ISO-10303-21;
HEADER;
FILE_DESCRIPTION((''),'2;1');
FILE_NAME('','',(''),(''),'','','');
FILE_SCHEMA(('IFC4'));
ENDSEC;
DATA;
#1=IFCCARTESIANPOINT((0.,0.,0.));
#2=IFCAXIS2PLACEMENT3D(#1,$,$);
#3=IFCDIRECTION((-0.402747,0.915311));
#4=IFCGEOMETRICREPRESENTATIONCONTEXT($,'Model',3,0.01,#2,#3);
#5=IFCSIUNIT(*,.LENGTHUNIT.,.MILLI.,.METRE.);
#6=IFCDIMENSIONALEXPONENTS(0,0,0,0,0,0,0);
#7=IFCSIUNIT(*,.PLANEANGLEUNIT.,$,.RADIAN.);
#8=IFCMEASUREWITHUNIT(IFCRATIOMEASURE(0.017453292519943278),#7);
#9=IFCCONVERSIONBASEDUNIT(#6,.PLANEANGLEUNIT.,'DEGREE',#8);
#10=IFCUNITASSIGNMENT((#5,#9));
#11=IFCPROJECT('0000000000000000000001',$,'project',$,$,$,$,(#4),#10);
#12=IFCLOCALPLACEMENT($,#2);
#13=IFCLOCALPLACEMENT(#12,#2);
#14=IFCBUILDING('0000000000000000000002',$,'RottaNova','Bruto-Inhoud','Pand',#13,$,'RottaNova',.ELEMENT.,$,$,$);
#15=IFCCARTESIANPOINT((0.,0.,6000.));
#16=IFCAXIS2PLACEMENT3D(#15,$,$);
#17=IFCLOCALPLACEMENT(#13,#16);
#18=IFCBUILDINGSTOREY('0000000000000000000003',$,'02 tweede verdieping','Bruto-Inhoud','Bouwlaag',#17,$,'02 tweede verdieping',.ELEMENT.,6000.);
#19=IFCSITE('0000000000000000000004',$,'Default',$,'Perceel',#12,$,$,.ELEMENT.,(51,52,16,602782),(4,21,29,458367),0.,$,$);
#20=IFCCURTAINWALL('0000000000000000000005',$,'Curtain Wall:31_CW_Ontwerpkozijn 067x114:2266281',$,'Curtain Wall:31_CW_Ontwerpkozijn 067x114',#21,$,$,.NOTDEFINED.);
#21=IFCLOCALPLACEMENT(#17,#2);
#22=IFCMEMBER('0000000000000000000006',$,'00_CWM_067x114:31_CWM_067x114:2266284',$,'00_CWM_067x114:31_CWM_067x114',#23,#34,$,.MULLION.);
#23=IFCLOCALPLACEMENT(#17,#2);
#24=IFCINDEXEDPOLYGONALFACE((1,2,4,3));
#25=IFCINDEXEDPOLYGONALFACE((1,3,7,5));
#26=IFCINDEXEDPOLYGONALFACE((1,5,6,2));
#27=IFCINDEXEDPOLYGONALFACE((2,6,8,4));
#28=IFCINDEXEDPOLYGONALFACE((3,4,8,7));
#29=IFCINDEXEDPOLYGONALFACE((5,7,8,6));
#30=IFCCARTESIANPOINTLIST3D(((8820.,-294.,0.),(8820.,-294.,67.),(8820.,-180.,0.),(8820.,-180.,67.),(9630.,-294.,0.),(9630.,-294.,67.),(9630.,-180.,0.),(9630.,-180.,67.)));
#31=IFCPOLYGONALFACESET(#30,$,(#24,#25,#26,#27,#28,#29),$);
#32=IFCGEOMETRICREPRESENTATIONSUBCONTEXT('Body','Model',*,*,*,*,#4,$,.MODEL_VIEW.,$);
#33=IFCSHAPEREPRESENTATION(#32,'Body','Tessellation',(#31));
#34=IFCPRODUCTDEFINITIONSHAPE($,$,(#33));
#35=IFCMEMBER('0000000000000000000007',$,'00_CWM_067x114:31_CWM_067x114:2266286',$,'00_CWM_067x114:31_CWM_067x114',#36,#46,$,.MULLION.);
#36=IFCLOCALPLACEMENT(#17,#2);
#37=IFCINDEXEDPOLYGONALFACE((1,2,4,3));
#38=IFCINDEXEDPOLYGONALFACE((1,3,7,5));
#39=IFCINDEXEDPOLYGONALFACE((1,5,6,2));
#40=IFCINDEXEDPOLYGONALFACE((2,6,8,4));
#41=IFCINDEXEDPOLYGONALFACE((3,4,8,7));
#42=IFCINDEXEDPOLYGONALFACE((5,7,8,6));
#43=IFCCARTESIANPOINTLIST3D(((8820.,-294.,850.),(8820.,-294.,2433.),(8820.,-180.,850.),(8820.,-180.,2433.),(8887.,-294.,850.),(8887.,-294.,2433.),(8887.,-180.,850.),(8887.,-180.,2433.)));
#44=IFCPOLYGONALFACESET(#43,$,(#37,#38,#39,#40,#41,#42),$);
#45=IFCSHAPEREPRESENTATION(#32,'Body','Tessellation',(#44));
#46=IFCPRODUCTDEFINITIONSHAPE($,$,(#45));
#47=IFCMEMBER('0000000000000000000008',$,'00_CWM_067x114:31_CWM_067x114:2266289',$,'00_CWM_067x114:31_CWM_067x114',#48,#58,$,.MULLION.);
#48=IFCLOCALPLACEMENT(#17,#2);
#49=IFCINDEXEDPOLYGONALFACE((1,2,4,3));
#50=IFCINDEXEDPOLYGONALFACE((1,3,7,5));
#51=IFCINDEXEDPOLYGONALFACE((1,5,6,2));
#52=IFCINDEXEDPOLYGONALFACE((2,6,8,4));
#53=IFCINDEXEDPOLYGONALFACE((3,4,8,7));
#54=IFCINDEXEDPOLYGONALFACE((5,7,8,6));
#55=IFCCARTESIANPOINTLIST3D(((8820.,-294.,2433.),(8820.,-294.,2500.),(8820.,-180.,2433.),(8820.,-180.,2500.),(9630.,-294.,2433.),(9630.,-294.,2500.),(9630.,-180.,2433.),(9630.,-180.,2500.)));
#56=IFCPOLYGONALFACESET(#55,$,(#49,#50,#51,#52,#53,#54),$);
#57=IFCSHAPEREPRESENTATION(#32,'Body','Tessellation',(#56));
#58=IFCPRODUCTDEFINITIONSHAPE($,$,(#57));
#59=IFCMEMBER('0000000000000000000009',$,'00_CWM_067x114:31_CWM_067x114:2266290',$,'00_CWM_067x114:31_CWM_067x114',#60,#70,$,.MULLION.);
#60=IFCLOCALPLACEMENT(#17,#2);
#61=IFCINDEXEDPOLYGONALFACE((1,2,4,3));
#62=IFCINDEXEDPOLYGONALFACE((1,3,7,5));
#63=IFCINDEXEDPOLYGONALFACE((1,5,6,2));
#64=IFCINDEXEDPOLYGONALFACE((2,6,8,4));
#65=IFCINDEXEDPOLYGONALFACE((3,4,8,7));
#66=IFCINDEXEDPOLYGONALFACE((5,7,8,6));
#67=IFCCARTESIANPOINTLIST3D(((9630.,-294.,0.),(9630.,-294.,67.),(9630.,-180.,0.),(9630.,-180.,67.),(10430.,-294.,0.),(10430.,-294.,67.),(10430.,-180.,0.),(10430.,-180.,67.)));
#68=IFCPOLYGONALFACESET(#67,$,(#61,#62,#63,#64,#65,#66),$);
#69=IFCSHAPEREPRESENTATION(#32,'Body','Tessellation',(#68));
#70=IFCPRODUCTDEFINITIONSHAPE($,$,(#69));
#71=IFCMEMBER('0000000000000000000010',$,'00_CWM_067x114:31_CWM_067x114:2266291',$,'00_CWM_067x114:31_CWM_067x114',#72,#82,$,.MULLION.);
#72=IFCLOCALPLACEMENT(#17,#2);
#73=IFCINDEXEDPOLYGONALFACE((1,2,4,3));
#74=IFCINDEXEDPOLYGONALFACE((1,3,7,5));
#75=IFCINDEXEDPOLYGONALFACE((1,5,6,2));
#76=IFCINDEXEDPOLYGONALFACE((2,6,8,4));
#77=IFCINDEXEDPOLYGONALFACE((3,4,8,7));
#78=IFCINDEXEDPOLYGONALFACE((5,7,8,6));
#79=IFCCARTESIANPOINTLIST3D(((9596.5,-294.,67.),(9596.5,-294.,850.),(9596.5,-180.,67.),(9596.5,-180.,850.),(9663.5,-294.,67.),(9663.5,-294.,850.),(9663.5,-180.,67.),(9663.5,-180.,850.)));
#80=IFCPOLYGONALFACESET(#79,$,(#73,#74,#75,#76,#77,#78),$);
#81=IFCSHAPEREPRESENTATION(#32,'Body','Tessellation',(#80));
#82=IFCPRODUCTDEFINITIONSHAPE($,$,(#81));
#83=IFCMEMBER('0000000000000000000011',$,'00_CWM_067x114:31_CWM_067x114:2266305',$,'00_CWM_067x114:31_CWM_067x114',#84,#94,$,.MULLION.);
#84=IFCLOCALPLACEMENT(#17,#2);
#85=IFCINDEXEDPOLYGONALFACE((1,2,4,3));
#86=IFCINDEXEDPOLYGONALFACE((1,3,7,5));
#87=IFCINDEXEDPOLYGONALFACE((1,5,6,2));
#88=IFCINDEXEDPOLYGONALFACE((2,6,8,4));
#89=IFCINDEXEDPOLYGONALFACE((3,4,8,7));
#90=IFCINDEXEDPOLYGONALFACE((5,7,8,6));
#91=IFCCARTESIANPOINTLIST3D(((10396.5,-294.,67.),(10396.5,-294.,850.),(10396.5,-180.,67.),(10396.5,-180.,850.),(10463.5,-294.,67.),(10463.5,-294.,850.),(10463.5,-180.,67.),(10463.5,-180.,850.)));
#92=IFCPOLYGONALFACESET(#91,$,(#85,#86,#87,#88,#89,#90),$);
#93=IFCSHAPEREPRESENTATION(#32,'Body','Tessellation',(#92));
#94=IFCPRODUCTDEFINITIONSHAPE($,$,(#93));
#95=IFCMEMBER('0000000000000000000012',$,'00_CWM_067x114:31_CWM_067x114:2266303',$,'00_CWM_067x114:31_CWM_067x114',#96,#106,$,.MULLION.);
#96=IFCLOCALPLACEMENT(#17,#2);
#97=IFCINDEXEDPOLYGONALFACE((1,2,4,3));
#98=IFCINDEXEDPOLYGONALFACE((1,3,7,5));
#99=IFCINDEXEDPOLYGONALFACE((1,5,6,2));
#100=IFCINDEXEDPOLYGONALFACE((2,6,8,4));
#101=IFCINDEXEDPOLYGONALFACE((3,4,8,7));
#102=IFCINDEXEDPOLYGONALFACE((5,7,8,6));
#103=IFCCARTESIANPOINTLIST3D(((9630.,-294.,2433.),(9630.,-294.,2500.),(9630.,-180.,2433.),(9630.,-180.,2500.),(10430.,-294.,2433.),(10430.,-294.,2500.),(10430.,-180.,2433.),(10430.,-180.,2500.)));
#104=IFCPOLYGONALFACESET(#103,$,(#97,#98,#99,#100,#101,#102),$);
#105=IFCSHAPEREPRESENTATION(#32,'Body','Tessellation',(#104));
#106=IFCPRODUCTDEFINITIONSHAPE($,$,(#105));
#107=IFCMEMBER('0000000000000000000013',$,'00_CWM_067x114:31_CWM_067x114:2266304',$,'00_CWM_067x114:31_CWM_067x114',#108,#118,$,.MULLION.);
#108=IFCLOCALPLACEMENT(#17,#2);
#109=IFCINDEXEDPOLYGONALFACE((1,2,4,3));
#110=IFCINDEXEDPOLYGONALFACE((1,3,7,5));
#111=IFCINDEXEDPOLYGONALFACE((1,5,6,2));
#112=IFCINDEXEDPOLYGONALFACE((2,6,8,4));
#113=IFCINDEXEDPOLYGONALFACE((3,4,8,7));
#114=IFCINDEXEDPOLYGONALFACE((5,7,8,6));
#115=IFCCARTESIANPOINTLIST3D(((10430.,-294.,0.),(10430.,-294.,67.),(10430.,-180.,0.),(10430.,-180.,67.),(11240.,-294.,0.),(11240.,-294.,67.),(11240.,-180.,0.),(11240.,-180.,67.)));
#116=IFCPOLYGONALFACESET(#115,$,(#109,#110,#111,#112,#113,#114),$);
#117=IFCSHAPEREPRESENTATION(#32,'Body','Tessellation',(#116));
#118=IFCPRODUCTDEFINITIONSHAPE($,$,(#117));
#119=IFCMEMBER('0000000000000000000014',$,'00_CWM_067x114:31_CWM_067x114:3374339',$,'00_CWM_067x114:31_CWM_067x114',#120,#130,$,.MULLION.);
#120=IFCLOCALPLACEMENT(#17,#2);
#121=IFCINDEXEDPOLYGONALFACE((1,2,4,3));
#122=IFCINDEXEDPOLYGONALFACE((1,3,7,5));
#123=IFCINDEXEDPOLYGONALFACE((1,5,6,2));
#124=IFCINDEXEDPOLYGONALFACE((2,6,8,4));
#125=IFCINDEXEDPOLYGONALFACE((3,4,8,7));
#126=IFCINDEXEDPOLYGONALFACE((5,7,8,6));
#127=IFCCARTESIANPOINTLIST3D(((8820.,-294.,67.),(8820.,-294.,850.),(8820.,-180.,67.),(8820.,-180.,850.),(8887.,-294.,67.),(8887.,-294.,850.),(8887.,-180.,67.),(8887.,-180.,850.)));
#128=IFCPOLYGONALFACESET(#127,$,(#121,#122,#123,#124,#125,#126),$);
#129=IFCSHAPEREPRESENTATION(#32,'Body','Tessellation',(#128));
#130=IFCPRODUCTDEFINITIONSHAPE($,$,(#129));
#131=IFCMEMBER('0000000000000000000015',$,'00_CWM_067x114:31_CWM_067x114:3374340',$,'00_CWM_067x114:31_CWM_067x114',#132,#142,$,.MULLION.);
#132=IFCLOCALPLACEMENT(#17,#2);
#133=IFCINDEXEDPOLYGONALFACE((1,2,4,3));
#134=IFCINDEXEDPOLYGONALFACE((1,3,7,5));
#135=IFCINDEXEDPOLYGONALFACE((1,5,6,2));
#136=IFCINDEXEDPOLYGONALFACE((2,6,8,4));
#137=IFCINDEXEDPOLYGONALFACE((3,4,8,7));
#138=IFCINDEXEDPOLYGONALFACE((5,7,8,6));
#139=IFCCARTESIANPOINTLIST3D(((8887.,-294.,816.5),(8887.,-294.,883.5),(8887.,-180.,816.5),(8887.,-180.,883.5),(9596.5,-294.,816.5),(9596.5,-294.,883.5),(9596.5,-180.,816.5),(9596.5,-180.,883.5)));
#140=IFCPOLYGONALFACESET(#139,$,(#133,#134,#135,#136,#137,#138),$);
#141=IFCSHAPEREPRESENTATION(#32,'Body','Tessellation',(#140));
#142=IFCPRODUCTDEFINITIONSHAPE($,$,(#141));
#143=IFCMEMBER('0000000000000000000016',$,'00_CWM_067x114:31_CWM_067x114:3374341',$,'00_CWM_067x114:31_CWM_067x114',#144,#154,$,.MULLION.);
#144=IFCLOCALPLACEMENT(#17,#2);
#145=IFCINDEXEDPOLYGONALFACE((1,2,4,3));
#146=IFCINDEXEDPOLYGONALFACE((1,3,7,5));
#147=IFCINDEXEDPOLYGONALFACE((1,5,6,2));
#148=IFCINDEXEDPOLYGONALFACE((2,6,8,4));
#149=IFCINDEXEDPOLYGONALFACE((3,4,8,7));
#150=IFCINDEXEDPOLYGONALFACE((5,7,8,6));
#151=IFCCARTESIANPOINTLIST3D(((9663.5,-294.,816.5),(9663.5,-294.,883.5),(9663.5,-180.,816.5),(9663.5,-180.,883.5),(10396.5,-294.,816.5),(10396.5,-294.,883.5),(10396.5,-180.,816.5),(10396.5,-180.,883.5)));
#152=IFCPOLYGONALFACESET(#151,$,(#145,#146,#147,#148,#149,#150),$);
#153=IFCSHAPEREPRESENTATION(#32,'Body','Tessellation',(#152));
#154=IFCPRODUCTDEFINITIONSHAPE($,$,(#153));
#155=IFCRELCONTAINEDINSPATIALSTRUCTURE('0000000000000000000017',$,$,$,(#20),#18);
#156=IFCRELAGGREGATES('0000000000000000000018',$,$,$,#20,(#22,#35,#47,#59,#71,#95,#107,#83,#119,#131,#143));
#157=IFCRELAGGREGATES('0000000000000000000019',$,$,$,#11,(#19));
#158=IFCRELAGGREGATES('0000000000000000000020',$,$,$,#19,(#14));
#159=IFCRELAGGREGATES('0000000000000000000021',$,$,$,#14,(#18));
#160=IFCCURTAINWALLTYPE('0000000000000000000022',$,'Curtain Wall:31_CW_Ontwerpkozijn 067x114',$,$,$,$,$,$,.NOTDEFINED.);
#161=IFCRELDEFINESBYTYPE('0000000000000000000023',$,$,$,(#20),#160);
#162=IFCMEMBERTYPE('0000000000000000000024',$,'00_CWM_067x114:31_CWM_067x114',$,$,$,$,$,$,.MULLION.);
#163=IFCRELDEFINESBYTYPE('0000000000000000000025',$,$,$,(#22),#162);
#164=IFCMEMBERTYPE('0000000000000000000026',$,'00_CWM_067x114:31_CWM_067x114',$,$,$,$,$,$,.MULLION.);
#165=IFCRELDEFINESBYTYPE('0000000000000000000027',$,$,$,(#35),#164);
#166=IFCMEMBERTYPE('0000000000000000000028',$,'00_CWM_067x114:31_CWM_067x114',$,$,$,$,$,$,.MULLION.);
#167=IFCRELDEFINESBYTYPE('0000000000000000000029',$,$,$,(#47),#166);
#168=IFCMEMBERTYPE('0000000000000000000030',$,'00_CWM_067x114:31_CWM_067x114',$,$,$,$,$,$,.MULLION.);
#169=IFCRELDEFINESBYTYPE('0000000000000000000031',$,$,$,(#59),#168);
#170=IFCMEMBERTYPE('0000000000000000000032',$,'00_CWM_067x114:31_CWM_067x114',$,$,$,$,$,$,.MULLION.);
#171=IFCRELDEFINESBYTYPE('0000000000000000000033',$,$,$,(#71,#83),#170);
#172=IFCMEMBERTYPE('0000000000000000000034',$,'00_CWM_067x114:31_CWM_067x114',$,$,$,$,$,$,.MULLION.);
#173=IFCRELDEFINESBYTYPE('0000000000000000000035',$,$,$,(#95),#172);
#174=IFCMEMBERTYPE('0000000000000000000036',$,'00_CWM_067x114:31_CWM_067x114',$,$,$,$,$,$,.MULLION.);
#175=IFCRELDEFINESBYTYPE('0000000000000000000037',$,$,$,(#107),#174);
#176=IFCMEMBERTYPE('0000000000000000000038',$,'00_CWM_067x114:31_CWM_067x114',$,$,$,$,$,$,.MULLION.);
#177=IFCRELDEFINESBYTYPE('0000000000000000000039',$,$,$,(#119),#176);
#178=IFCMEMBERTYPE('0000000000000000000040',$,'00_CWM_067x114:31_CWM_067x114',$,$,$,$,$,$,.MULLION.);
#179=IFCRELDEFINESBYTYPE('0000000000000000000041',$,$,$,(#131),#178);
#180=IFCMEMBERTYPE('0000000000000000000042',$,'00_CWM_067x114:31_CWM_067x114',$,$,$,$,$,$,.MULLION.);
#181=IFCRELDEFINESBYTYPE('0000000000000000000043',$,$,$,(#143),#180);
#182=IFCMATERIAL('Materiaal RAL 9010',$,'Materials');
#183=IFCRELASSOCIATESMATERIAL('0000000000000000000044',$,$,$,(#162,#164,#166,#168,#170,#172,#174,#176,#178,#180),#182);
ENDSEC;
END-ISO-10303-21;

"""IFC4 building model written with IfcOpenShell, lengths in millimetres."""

from ifc_helpers import new_model, entity, si_unit, converted_unit, direction, frame, origin, origin_2d_with_axis, place, context, subcontext, project, spatial, rectangle, extrude, source, transform, mapped, material, material_profile, profile_set, type_object, type_shapes, element, aggregate, save


model = new_model("IFC4")

# Units and contexts
model_context = context("Model", 3, precision=0.01, world=origin(), true_north=direction((-0.402747, 0.915311)))
body_context = subcontext(model_context, "Body", "Model", "MODEL_VIEW")
ifc_project = project(units=[si_unit("LENGTHUNIT", "METRE", prefix="MILLI"), converted_unit("PLANEANGLEUNIT", "DEGREE", entity("IfcRatioMeasure", 0.017453292519943278), si_unit("PLANEANGLEUNIT", "RADIAN"), dimensions=[0, 0, 0, 0, 0, 0, 0])], contexts=[model_context])

# Site, building, storey
site_placement = place(None, origin())
site = spatial("IfcSite", under=ifc_project, at=site_placement, Name="Default", ObjectType="Perceel", CompositionType="ELEMENT", RefLatitude=(51, 52, 16, 602782), RefLongitude=(4, 21, 29, 458367), RefElevation=0.0)
building_placement = place(site_placement, origin())
building = spatial("IfcBuilding", under=site, at=building_placement, Name="RottaNova", Description="Bruto-Inhoud", ObjectType="Pand", LongName="RottaNova", CompositionType="ELEMENT")
storey_placement = place(building_placement, frame((0.0, 0.0, 6000.0)))
storey = spatial("IfcBuildingStorey", under=building, at=storey_placement, Name="02 tweede verdieping", Description="Bruto-Inhoud", ObjectType="Bouwlaag", LongName="02 tweede verdieping", CompositionType="ELEMENT", Elevation=6000.0)

# Curtain wall, members
curtain_wall_type = type_object("IfcCurtainWallType", Name="Curtain Wall:31_CW_Ontwerpkozijn 067x114", PredefinedType="NOTDEFINED")
curtain_wall_1_placement = place(storey_placement, frame((0.0, 0.0, -6000.0)))
curtain_wall_1 = element("IfcCurtainWall", 1, at=curtain_wall_1_placement, inside=storey, type_object=curtain_wall_type, Name="Curtain Wall:31_CW_Ontwerpkozijn 067x114:2266281", ObjectType="Curtain Wall:31_CW_Ontwerpkozijn 067x114", PredefinedType="NOTDEFINED")
ifc_material_1 = material(Name="Materiaal RAL 9010", Category="Materials")
ifc_material_profile = material_profile(ifc_material_1, rectangle(XDim=114.0, YDim=67.0, at=origin_2d_with_axis()), Name="31_CWM_067x114")
ifc_profile_set = profile_set([ifc_material_profile], Name="31_CWM_067x114")
member_type_1 = type_object("IfcMemberType", Name="00_CWM_067x114:31_CWM_067x114", PredefinedType="MULLION", material=ifc_profile_set)
shared_shape_1 = source(origin(), body_context, "Body", "SweptSolid", [
    extrude(rectangle(XDim=114.0, YDim=67.0, at=origin_2d_with_axis()), frame((-33.5, 57.0, -810.0), z_axis=(0.0, 0.0, 1.0), x_axis=(0.0, -1.0, 0.0)), (0.0, 0.0, 1.0), 810.0),
])
type_shapes(member_type_1, [shared_shape_1])
member_1_placement = place(curtain_wall_1_placement, frame((8820.0, -180.0, 6000.0), z_axis=(-1.0, 0.0, 0.0), x_axis=(0.0, 0.0, -1.0)))
member_1 = element("IfcMember", 2, at=member_1_placement, type_object=member_type_1, Name="00_CWM_067x114:31_CWM_067x114:2266284", ObjectType="00_CWM_067x114:31_CWM_067x114", PredefinedType="MULLION", context=body_context, shape_type="MappedRepresentation", body=[
    mapped(shared_shape_1, transform((0.0, 0.0, 0.0), scale=1.0)),
])
member_type_2 = type_object("IfcMemberType", Name="00_CWM_067x114:31_CWM_067x114", PredefinedType="MULLION", material=ifc_profile_set)
shared_shape_2 = source(origin(), body_context, "Body", "SweptSolid", [
    extrude(rectangle(XDim=114.0, YDim=67.0, at=origin_2d_with_axis()), frame((-33.5, 57.0, -1583.0), z_axis=(0.0, 0.0, 1.0), x_axis=(0.0, -1.0, 0.0)), (0.0, 0.0, 1.0), 1583.0),
])
type_shapes(member_type_2, [shared_shape_2])
member_2_placement = place(curtain_wall_1_placement, frame((8820.0, -180.0, 8433.0), z_axis=(0.0, 0.0, 1.0), x_axis=(-1.0, 0.0, 0.0)))
member_2 = element("IfcMember", 3, at=member_2_placement, type_object=member_type_2, Name="00_CWM_067x114:31_CWM_067x114:2266286", ObjectType="00_CWM_067x114:31_CWM_067x114", PredefinedType="MULLION", context=body_context, shape_type="MappedRepresentation", body=[
    mapped(shared_shape_2, transform((0.0, 0.0, 0.0), scale=1.0)),
])
member_type_3 = type_object("IfcMemberType", Name="00_CWM_067x114:31_CWM_067x114", PredefinedType="MULLION", material=ifc_profile_set)
shared_shape_3 = source(origin(), body_context, "Body", "SweptSolid", [
    extrude(rectangle(XDim=114.0, YDim=67.0, at=origin_2d_with_axis()), frame((-33.5, 57.0, -810.0), z_axis=(0.0, 0.0, 1.0), x_axis=(0.0, -1.0, 0.0)), (0.0, 0.0, 1.0), 810.0),
])
type_shapes(member_type_3, [shared_shape_3])
member_3_placement = place(curtain_wall_1_placement, frame((9630.0, -180.0, 8500.0), z_axis=(1.0, 0.0, 0.0), x_axis=(0.0, 0.0, 1.0)))
member_3 = element("IfcMember", 4, at=member_3_placement, type_object=member_type_3, Name="00_CWM_067x114:31_CWM_067x114:2266289", ObjectType="00_CWM_067x114:31_CWM_067x114", PredefinedType="MULLION", context=body_context, shape_type="MappedRepresentation", body=[
    mapped(shared_shape_3, transform((0.0, 0.0, 0.0), scale=1.0)),
])
member_type_4 = type_object("IfcMemberType", Name="00_CWM_067x114:31_CWM_067x114", PredefinedType="MULLION", material=ifc_profile_set)
shared_shape_4 = source(origin(), body_context, "Body", "SweptSolid", [
    extrude(rectangle(XDim=114.0, YDim=67.0, at=origin_2d_with_axis()), frame((-33.5, 57.0, -800.0), z_axis=(0.0, 0.0, 1.0), x_axis=(0.0, -1.0, 0.0)), (0.0, 0.0, 1.0), 800.0),
])
type_shapes(member_type_4, [shared_shape_4])
member_4_placement = place(curtain_wall_1_placement, frame((9630.0, -180.0, 6000.0), z_axis=(-1.0, 0.0, 0.0), x_axis=(0.0, 0.0, -1.0)))
member_4 = element("IfcMember", 5, at=member_4_placement, type_object=member_type_4, Name="00_CWM_067x114:31_CWM_067x114:2266290", ObjectType="00_CWM_067x114:31_CWM_067x114", PredefinedType="MULLION", context=body_context, shape_type="MappedRepresentation", body=[
    mapped(shared_shape_4, transform((0.0, 0.0, 0.0), scale=1.0)),
])
member_type_5 = type_object("IfcMemberType", Name="00_CWM_067x114:31_CWM_067x114", PredefinedType="MULLION", material=ifc_profile_set)
shared_shape_5 = source(origin(), body_context, "Body", "SweptSolid", [
    extrude(rectangle(XDim=114.0, YDim=67.0, at=origin_2d_with_axis()), frame((0.0, 57.0, -783.0), z_axis=(0.0, 0.0, 1.0), x_axis=(0.0, -1.0, 0.0)), (0.0, 0.0, 1.0), 783.0),
])
type_shapes(member_type_5, [shared_shape_5])
member_5_placement = place(curtain_wall_1_placement, frame((9630.0, -180.0, 6067.0), z_axis=(0.0, 0.0, -1.0), x_axis=(1.0, 0.0, 0.0)))
member_5 = element("IfcMember", 6, at=member_5_placement, type_object=member_type_5, Name="00_CWM_067x114:31_CWM_067x114:2266291", ObjectType="00_CWM_067x114:31_CWM_067x114", PredefinedType="MULLION", context=body_context, shape_type="MappedRepresentation", body=[
    mapped(shared_shape_5, transform((0.0, 0.0, 0.0), scale=1.0)),
])
member_6_placement = place(curtain_wall_1_placement, frame((10430.0, -180.0, 6067.0), z_axis=(0.0, 0.0, -1.0), x_axis=(1.0, 0.0, 0.0)))
member_6 = element("IfcMember", 7, at=member_6_placement, type_object=member_type_5, Name="00_CWM_067x114:31_CWM_067x114:2266305", ObjectType="00_CWM_067x114:31_CWM_067x114", PredefinedType="MULLION", context=body_context, shape_type="MappedRepresentation", body=[
    mapped(shared_shape_5, transform((0.0, 0.0, 0.0), scale=1.0)),
])
member_type_6 = type_object("IfcMemberType", Name="00_CWM_067x114:31_CWM_067x114", PredefinedType="MULLION", material=ifc_profile_set)
shared_shape_6 = source(origin(), body_context, "Body", "SweptSolid", [
    extrude(rectangle(XDim=114.0, YDim=67.0, at=origin_2d_with_axis()), frame((-33.5, 57.0, -800.0), z_axis=(0.0, 0.0, 1.0), x_axis=(0.0, -1.0, 0.0)), (0.0, 0.0, 1.0), 800.0),
])
type_shapes(member_type_6, [shared_shape_6])
member_7_placement = place(curtain_wall_1_placement, frame((10430.0, -180.0, 8500.0), z_axis=(1.0, 0.0, 0.0), x_axis=(0.0, 0.0, 1.0)))
member_7 = element("IfcMember", 8, at=member_7_placement, type_object=member_type_6, Name="00_CWM_067x114:31_CWM_067x114:2266303", ObjectType="00_CWM_067x114:31_CWM_067x114", PredefinedType="MULLION", context=body_context, shape_type="MappedRepresentation", body=[
    mapped(shared_shape_6, transform((0.0, 0.0, 0.0), scale=1.0)),
])
member_type_7 = type_object("IfcMemberType", Name="00_CWM_067x114:31_CWM_067x114", PredefinedType="MULLION", material=ifc_profile_set)
shared_shape_7 = source(origin(), body_context, "Body", "SweptSolid", [
    extrude(rectangle(XDim=114.0, YDim=67.0, at=origin_2d_with_axis()), frame((-33.5, 57.0, -810.0), z_axis=(0.0, 0.0, 1.0), x_axis=(0.0, -1.0, 0.0)), (0.0, 0.0, 1.0), 810.0),
])
type_shapes(member_type_7, [shared_shape_7])
member_8_placement = place(curtain_wall_1_placement, frame((10430.0, -180.0, 6000.0), z_axis=(-1.0, 0.0, 0.0), x_axis=(0.0, 0.0, -1.0)))
member_8 = element("IfcMember", 9, at=member_8_placement, type_object=member_type_7, Name="00_CWM_067x114:31_CWM_067x114:2266304", ObjectType="00_CWM_067x114:31_CWM_067x114", PredefinedType="MULLION", context=body_context, shape_type="MappedRepresentation", body=[
    mapped(shared_shape_7, transform((0.0, 0.0, 0.0), scale=1.0)),
])
member_type_8 = type_object("IfcMemberType", Name="00_CWM_067x114:31_CWM_067x114", PredefinedType="MULLION", material=ifc_profile_set)
shared_shape_8 = source(origin(), body_context, "Body", "SweptSolid", [
    extrude(rectangle(XDim=114.0, YDim=67.0, at=origin_2d_with_axis()), frame((-33.5, 57.0, -783.0), z_axis=(0.0, 0.0, 1.0), x_axis=(0.0, -1.0, 0.0)), (0.0, 0.0, 1.0), 783.0),
])
type_shapes(member_type_8, [shared_shape_8])
member_9_placement = place(curtain_wall_1_placement, frame((8820.0, -180.0, 6850.0), z_axis=(0.0, 0.0, 1.0), x_axis=(-1.0, 0.0, 0.0)))
member_9 = element("IfcMember", 10, at=member_9_placement, type_object=member_type_8, Name="00_CWM_067x114:31_CWM_067x114:3374339", ObjectType="00_CWM_067x114:31_CWM_067x114", PredefinedType="MULLION", context=body_context, shape_type="MappedRepresentation", body=[
    mapped(shared_shape_8, transform((0.0, 0.0, 0.0), scale=1.0)),
])
member_type_9 = type_object("IfcMemberType", Name="00_CWM_067x114:31_CWM_067x114", PredefinedType="MULLION", material=ifc_profile_set)
shared_shape_9 = source(origin(), body_context, "Body", "SweptSolid", [
    extrude(rectangle(XDim=114.0, YDim=67.0, at=origin_2d_with_axis()), frame((0.0, 57.0, -709.5), z_axis=(0.0, 0.0, 1.0), x_axis=(0.0, -1.0, 0.0)), (0.0, 0.0, 1.0), 709.5),
])
type_shapes(member_type_9, [shared_shape_9])
member_10_placement = place(curtain_wall_1_placement, frame((9596.5, -180.0, 6850.0), z_axis=(1.0, 0.0, 0.0), x_axis=(0.0, 0.0, 1.0)))
member_10 = element("IfcMember", 11, at=member_10_placement, type_object=member_type_9, Name="00_CWM_067x114:31_CWM_067x114:3374340", ObjectType="00_CWM_067x114:31_CWM_067x114", PredefinedType="MULLION", context=body_context, shape_type="MappedRepresentation", body=[
    mapped(shared_shape_9, transform((0.0, 0.0, 0.0), scale=1.0)),
])
member_type_10 = type_object("IfcMemberType", Name="00_CWM_067x114:31_CWM_067x114", PredefinedType="MULLION", material=ifc_profile_set)
shared_shape_10 = source(origin(), body_context, "Body", "SweptSolid", [
    extrude(rectangle(XDim=114.0, YDim=67.0, at=origin_2d_with_axis()), frame((0.0, 57.0, -733.0), z_axis=(0.0, 0.0, 1.0), x_axis=(0.0, -1.0, 0.0)), (0.0, 0.0, 1.0), 733.0),
])
type_shapes(member_type_10, [shared_shape_10])
member_11_placement = place(curtain_wall_1_placement, frame((10396.5, -180.0, 6850.0), z_axis=(1.0, 0.0, 0.0), x_axis=(0.0, 0.0, 1.0)))
member_11 = element("IfcMember", 12, at=member_11_placement, type_object=member_type_10, Name="00_CWM_067x114:31_CWM_067x114:3374341", ObjectType="00_CWM_067x114:31_CWM_067x114", PredefinedType="MULLION", context=body_context, shape_type="MappedRepresentation", body=[
    mapped(shared_shape_10, transform((0.0, 0.0, 0.0), scale=1.0)),
])

aggregate(curtain_wall_1, [member_1, member_2, member_3, member_4, member_5, member_7, member_8, member_6, member_9, member_10, member_11])

save(model, "model.ifc")
